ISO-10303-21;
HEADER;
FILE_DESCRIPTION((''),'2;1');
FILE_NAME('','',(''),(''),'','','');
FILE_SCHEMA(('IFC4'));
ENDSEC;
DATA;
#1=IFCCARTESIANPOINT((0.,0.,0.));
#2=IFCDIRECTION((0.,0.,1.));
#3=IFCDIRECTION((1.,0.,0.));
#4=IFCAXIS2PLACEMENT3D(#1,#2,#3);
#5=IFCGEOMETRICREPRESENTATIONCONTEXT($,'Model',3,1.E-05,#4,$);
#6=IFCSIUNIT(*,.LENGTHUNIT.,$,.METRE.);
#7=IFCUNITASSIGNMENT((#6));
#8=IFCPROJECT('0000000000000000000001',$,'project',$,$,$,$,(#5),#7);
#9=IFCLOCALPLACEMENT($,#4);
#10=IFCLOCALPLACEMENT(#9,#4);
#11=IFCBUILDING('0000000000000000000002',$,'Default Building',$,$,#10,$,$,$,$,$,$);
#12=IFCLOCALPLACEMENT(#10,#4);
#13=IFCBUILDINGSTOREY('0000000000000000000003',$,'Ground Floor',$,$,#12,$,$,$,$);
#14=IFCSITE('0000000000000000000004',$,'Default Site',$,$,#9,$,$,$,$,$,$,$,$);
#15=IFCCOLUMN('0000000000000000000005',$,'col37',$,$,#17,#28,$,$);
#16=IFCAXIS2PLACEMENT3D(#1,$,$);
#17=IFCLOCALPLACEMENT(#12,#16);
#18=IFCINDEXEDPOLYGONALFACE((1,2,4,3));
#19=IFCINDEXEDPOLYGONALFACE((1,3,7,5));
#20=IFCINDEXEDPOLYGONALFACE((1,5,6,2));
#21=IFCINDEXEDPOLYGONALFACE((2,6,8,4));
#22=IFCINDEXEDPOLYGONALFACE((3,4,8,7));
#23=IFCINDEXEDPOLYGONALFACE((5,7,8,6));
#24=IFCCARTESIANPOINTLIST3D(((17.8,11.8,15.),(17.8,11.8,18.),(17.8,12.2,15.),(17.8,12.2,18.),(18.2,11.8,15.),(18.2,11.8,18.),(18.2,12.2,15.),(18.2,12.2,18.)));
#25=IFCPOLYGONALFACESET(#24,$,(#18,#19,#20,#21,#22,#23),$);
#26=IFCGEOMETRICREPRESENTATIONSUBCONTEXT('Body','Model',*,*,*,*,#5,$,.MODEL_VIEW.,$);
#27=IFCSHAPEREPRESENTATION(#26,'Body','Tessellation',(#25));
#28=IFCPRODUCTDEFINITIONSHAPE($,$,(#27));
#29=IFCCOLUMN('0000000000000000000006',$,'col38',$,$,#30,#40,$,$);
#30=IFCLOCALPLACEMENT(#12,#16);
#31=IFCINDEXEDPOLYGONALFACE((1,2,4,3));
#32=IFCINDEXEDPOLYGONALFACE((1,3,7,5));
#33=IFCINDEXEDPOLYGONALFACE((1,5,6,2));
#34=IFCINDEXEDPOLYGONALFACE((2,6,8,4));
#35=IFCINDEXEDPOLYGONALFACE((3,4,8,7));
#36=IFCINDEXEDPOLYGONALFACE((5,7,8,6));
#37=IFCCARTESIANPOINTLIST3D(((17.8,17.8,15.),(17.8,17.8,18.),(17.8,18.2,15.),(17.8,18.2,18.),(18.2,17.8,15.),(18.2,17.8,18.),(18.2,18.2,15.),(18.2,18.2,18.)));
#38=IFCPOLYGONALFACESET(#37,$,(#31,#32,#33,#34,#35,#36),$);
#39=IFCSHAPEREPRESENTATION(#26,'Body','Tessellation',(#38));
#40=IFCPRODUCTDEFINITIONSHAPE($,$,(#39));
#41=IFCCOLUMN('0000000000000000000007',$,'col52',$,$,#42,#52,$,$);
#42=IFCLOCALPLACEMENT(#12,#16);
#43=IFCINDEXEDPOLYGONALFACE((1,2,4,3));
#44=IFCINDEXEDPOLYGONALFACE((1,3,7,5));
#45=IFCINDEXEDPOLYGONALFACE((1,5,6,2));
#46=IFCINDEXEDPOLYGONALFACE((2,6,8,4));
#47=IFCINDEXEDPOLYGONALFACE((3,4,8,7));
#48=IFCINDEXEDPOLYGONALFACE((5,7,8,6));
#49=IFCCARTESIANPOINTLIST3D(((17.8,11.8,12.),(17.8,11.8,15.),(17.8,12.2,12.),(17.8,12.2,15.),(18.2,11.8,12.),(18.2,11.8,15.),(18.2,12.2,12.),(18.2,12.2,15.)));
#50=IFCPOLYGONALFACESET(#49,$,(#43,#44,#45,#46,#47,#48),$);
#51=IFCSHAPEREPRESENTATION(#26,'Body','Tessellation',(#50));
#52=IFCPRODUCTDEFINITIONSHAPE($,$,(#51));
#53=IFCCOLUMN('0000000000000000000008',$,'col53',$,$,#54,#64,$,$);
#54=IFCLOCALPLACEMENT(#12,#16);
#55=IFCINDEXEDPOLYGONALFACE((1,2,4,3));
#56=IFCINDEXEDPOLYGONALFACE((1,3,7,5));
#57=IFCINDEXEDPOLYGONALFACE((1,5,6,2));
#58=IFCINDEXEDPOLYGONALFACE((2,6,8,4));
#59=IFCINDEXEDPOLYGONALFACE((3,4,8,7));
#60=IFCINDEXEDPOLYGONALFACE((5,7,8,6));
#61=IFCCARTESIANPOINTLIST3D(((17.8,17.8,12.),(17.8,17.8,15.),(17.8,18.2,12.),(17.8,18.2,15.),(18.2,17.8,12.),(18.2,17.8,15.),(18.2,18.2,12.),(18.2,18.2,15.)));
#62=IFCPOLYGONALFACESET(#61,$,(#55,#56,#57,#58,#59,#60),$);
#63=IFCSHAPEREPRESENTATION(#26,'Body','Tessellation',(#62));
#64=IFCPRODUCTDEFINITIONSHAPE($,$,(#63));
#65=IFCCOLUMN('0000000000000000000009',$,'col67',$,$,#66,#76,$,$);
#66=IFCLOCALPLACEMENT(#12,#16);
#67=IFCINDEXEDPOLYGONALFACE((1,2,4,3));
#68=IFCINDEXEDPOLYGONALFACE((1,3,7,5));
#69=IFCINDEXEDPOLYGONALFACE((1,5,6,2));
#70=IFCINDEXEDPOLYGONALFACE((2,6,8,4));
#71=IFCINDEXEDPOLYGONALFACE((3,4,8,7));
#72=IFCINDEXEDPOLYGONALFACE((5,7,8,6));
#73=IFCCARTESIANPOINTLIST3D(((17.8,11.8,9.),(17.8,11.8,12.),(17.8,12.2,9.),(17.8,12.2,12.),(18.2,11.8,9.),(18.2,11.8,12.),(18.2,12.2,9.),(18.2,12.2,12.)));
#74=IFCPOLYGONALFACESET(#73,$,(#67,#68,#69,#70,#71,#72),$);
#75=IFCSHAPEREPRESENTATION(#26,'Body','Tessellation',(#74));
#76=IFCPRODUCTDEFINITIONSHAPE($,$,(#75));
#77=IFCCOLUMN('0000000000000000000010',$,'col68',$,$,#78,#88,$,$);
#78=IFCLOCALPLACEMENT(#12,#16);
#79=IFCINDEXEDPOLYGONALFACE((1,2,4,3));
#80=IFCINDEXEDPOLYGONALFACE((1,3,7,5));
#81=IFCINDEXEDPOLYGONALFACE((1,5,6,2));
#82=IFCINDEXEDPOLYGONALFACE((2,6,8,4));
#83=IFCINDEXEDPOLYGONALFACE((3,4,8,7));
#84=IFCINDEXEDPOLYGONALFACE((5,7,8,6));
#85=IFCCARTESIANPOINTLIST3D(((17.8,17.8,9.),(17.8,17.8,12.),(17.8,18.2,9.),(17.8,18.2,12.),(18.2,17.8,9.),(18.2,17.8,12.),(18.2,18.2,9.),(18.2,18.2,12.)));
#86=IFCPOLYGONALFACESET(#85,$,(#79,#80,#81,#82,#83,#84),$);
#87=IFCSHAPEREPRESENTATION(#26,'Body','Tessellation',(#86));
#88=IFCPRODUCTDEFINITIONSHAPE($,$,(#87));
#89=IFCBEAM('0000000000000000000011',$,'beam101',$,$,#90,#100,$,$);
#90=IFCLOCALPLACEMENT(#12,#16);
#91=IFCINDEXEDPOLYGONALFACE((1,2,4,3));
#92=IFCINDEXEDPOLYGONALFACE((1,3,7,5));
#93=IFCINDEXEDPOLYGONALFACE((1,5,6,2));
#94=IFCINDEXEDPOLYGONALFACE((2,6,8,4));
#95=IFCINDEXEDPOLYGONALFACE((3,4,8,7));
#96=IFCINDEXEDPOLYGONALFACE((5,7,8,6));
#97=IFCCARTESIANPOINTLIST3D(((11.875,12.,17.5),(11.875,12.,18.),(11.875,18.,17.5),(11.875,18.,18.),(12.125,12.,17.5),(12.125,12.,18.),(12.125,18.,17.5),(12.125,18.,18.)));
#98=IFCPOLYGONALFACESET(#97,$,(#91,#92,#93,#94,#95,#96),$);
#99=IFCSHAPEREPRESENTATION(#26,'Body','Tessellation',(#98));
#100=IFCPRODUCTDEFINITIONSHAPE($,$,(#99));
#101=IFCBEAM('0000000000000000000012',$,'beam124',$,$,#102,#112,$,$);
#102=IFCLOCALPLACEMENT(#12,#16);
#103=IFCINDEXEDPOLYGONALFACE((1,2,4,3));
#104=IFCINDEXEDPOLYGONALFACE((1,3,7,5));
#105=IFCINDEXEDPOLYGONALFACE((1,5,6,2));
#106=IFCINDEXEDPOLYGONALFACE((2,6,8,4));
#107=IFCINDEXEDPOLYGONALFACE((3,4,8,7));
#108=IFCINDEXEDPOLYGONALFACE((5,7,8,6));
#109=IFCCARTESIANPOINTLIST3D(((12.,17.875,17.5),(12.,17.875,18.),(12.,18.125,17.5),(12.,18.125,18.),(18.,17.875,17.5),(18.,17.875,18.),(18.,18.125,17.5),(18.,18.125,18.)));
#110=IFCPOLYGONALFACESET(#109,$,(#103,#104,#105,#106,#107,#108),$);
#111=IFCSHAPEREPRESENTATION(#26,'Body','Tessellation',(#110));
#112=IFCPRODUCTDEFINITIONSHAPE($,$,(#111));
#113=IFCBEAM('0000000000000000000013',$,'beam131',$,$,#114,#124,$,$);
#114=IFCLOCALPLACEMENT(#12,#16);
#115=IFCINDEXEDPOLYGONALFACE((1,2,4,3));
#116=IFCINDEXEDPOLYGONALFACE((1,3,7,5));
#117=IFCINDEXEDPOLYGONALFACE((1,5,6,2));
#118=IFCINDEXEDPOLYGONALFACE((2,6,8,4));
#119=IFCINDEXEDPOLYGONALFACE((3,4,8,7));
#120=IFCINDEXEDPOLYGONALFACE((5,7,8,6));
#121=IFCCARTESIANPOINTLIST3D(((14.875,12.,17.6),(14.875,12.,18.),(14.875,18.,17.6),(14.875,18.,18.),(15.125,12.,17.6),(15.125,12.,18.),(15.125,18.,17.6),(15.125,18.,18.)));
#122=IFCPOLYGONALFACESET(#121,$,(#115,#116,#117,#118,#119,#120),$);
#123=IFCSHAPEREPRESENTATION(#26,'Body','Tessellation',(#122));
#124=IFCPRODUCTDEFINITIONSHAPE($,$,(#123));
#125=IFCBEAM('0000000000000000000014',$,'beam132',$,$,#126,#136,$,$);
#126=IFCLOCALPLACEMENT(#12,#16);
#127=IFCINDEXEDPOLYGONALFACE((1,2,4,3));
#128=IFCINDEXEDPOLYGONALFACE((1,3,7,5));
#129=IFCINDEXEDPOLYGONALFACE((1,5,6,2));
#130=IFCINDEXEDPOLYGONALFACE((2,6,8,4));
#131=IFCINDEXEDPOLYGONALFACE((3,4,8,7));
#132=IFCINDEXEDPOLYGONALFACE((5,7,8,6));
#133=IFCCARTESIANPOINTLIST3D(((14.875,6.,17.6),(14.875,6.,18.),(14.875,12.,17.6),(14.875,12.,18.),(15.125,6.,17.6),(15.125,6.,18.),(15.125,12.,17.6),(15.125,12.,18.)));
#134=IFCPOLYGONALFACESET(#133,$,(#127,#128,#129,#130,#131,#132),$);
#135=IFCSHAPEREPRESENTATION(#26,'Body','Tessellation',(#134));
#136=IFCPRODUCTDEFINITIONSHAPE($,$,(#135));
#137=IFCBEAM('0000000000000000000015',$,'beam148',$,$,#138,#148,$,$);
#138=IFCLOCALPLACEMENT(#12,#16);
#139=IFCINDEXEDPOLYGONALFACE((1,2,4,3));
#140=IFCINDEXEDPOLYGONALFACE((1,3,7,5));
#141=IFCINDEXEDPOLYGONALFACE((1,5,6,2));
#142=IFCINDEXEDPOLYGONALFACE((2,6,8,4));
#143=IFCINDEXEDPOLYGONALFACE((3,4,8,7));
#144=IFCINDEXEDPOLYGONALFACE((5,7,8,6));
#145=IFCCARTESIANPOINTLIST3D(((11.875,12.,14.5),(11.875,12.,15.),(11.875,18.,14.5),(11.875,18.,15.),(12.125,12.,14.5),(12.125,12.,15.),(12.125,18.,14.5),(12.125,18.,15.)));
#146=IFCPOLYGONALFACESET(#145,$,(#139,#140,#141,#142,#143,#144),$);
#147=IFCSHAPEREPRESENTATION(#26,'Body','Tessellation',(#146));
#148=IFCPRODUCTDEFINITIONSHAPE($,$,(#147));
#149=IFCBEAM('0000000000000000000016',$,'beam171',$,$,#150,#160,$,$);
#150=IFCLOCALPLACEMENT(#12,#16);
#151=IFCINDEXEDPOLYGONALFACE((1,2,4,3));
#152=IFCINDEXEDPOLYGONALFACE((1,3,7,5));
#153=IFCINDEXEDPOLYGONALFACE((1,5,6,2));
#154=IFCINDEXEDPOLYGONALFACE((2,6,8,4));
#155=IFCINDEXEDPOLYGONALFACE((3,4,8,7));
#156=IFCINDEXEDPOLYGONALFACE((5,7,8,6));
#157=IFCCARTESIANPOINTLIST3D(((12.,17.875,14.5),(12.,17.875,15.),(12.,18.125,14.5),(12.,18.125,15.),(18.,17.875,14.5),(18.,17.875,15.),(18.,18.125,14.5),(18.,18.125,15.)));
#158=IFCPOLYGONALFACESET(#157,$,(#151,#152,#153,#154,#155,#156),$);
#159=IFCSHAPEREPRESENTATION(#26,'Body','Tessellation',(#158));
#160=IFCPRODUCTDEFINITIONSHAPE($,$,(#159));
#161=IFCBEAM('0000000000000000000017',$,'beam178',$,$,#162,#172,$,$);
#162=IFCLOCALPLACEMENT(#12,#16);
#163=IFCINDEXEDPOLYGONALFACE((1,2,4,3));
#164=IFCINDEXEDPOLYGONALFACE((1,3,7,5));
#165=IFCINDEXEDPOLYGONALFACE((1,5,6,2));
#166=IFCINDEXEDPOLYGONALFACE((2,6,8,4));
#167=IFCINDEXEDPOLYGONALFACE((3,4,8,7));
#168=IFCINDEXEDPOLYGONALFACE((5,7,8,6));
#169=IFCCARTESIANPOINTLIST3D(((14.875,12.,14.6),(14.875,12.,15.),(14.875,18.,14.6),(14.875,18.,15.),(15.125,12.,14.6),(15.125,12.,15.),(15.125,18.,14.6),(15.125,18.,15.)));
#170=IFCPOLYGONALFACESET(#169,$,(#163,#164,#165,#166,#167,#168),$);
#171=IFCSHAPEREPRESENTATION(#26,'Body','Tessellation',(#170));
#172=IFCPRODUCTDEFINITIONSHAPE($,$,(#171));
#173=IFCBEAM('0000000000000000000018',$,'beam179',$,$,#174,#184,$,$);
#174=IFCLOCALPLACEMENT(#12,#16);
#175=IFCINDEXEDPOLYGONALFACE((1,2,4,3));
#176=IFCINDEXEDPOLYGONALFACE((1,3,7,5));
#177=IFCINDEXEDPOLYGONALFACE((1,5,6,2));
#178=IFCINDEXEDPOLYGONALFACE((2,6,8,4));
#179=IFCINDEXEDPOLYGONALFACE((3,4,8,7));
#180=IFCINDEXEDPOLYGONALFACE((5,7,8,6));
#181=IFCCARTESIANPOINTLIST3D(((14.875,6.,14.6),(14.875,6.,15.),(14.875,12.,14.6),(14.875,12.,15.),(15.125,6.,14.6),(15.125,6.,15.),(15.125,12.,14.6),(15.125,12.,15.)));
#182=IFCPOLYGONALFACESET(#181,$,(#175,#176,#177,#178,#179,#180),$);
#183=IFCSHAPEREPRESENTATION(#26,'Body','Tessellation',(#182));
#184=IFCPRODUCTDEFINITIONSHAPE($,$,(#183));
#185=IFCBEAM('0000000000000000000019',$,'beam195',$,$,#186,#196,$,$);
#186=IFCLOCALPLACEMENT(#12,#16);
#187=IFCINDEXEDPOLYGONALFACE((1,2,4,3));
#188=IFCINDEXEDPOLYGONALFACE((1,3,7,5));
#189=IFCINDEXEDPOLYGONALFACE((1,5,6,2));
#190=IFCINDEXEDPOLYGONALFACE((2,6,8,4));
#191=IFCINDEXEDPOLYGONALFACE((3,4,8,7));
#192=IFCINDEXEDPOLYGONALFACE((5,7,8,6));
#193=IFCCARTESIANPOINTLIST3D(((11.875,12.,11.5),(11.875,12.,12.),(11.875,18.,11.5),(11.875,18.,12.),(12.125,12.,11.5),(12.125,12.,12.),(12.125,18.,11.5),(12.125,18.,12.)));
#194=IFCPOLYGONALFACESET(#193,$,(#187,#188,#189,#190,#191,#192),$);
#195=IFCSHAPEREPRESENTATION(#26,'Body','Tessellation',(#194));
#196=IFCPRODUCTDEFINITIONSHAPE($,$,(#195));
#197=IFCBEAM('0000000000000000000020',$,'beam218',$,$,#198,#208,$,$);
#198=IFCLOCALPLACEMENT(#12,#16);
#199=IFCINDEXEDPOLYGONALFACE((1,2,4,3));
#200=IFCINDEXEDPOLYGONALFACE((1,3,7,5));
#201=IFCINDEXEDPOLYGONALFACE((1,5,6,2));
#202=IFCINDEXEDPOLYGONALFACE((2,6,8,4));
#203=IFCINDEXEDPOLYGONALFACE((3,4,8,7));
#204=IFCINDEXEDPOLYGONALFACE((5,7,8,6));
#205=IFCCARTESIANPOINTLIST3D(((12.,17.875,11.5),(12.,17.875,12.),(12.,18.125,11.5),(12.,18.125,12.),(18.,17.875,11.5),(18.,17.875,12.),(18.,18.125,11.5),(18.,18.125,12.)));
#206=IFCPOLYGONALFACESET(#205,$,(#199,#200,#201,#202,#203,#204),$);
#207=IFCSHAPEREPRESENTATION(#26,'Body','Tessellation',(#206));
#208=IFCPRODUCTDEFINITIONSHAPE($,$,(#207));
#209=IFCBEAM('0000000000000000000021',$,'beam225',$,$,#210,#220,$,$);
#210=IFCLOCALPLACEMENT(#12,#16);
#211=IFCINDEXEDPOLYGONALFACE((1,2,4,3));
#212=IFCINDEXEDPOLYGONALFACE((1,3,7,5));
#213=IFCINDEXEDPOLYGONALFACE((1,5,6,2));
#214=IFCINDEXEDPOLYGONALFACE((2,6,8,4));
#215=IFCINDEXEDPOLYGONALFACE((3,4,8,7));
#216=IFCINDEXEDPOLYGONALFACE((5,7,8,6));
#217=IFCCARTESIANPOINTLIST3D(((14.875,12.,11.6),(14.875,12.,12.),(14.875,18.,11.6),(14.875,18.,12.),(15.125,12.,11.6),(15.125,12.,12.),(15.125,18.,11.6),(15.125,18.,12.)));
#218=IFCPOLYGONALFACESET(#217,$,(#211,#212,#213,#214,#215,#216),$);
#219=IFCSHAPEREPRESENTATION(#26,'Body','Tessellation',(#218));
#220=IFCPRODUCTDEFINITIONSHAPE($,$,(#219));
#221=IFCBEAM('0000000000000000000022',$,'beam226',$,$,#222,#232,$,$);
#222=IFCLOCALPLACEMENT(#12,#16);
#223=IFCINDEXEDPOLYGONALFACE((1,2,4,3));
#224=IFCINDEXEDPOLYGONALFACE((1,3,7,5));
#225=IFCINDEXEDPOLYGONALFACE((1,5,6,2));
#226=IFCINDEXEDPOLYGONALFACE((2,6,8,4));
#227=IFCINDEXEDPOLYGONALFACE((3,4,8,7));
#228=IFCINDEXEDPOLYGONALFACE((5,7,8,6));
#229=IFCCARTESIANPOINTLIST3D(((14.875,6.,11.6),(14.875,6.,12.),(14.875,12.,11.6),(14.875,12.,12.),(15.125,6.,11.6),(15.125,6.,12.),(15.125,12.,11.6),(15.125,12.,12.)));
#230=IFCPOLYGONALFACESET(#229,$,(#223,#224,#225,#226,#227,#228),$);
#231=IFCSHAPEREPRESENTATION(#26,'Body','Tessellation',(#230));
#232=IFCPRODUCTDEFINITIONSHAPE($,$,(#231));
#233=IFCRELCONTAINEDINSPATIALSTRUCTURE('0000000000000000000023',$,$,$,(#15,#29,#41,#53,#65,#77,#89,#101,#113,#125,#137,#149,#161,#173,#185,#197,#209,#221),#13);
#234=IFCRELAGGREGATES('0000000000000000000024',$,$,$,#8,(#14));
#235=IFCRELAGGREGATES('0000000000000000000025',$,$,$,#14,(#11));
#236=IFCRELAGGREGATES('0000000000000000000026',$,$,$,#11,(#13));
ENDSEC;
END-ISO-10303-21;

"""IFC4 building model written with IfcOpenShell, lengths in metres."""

from ifc_helpers import new_model, si_unit, frame, origin_with_axes, place, context, subcontext, project, spatial, indexed_curve, outline, extrude, element, save


model = new_model("IFC4")

# Units and contexts
model_context = context("Model", 3, precision=1e-05, world=origin_with_axes())
body_context = subcontext(model_context, "Body", "Model", "MODEL_VIEW")
ifc_project = project(units=[si_unit("LENGTHUNIT", "METRE")], contexts=[model_context])

# Site, building, storey
site_placement = place(None, origin_with_axes())
site = spatial("IfcSite", under=ifc_project, at=site_placement, Name="Default Site")
building_placement = place(site_placement, origin_with_axes())
building = spatial("IfcBuilding", under=site, at=building_placement, Name="Default Building")
storey_placement = place(building_placement, origin_with_axes())
storey = spatial("IfcBuildingStorey", under=building, at=storey_placement, Name="Ground Floor")

# Columns
for number, where, z_axis, x_axis, name in (
    (1, (17.8, 11.8, 15.0), (0.0, 0.0, 1.0), (1.0, 0.0, 0.0), "col37"),
    (2, (17.8, 17.8, 15.0), (0.0, 0.0, 1.0), (1.0, 0.0, 0.0), "col38"),
    (3, (17.8, 11.8, 12.0), (0.0, 0.0, 1.0), (1.0, 0.0, 0.0), "col52"),
    (4, (17.8, 17.8, 12.0), (0.0, 0.0, 1.0), (1.0, 0.0, 0.0), "col53"),
    (5, (17.8, 11.8, 9.0), (0.0, 0.0, 1.0), (1.0, 0.0, 0.0), "col67"),
    (6, (17.8, 17.8, 9.0), (0.0, 0.0, 1.0), (1.0, 0.0, 0.0), "col68"),
):
    element("IfcColumn", number, at=place(storey_placement, frame(where, z_axis=z_axis, x_axis=x_axis)), inside=storey, Name=name, context=body_context, shape_type="SweptSolid", body=[
        extrude(outline(indexed_curve([(0.0, 0.0), (0.0, 0.4), (0.4, 0.4), (0.4, 0.0), (0.0, 0.0)], self_intersect=False)), origin_with_axes(), (0.0, 0.0, 1.0), 3.0),
    ])

# Beams
for number, where, z_axis, x_axis, name in (
    (7, (12.125, 12.0, 17.5), (0.0, 0.0, 1.0), (0.0, 1.0, 0.0), "beam101"),
    (8, (12.0, 17.875, 17.5), (0.0, 0.0, 1.0), (1.0, 0.0, 0.0), "beam124"),
):
    element("IfcBeam", number, at=place(storey_placement, frame(where, z_axis=z_axis, x_axis=x_axis)), inside=storey, Name=name, context=body_context, shape_type="SweptSolid", body=[
        extrude(outline(indexed_curve([(0.0, 0.0), (0.0, 0.25), (6.0, 0.25), (6.0, 0.0), (0.0, 0.0)], self_intersect=False)), origin_with_axes(), (0.0, 0.0, 1.0), 0.5),
    ])
for number, where, z_axis, x_axis, name in (
    (9, (14.875, 18.0, 17.6), (0.0, 0.0, 1.0), (0.0, -1.0, 0.0), "beam131"),
    (10, (14.875, 12.0, 17.6), (0.0, 0.0, 1.0), (0.0, -1.0, 0.0), "beam132"),
):
    element("IfcBeam", number, at=place(storey_placement, frame(where, z_axis=z_axis, x_axis=x_axis)), inside=storey, Name=name, context=body_context, shape_type="SweptSolid", body=[
        extrude(outline(indexed_curve([(0.0, 0.0), (0.0, 0.25), (6.0, 0.25), (6.0, 0.0), (0.0, 0.0)], self_intersect=False)), origin_with_axes(), (0.0, 0.0, 1.0), 0.4),
    ])
for number, where, z_axis, x_axis, name in (
    (11, (12.125, 12.0, 14.5), (0.0, 0.0, 1.0), (0.0, 1.0, 0.0), "beam148"),
    (12, (12.0, 17.875, 14.5), (0.0, 0.0, 1.0), (1.0, 0.0, 0.0), "beam171"),
):
    element("IfcBeam", number, at=place(storey_placement, frame(where, z_axis=z_axis, x_axis=x_axis)), inside=storey, Name=name, context=body_context, shape_type="SweptSolid", body=[
        extrude(outline(indexed_curve([(0.0, 0.0), (0.0, 0.25), (6.0, 0.25), (6.0, 0.0), (0.0, 0.0)], self_intersect=False)), origin_with_axes(), (0.0, 0.0, 1.0), 0.5),
    ])
for number, where, z_axis, x_axis, name in (
    (13, (14.875, 18.0, 14.6), (0.0, 0.0, 1.0), (0.0, -1.0, 0.0), "beam178"),
    (14, (14.875, 12.0, 14.6), (0.0, 0.0, 1.0), (0.0, -1.0, 0.0), "beam179"),
):
    element("IfcBeam", number, at=place(storey_placement, frame(where, z_axis=z_axis, x_axis=x_axis)), inside=storey, Name=name, context=body_context, shape_type="SweptSolid", body=[
        extrude(outline(indexed_curve([(0.0, 0.0), (0.0, 0.25), (6.0, 0.25), (6.0, 0.0), (0.0, 0.0)], self_intersect=False)), origin_with_axes(), (0.0, 0.0, 1.0), 0.4),
    ])
for number, where, z_axis, x_axis, name in (
    (15, (12.125, 12.0, 11.5), (0.0, 0.0, 1.0), (0.0, 1.0, 0.0), "beam195"),
    (16, (12.0, 17.875, 11.5), (0.0, 0.0, 1.0), (1.0, 0.0, 0.0), "beam218"),
):
    element("IfcBeam", number, at=place(storey_placement, frame(where, z_axis=z_axis, x_axis=x_axis)), inside=storey, Name=name, context=body_context, shape_type="SweptSolid", body=[
        extrude(outline(indexed_curve([(0.0, 0.0), (0.0, 0.25), (6.0, 0.25), (6.0, 0.0), (0.0, 0.0)], self_intersect=False)), origin_with_axes(), (0.0, 0.0, 1.0), 0.5),
    ])
for number, where, z_axis, x_axis, name in (
    (17, (14.875, 18.0, 11.6), (0.0, 0.0, 1.0), (0.0, -1.0, 0.0), "beam225"),
    (18, (14.875, 12.0, 11.6), (0.0, 0.0, 1.0), (0.0, -1.0, 0.0), "beam226"),
):
    element("IfcBeam", number, at=place(storey_placement, frame(where, z_axis=z_axis, x_axis=x_axis)), inside=storey, Name=name, context=body_context, shape_type="SweptSolid", body=[
        extrude(outline(indexed_curve([(0.0, 0.0), (0.0, 0.25), (6.0, 0.25), (6.0, 0.0), (0.0, 0.0)], self_intersect=False)), origin_with_axes(), (0.0, 0.0, 1.0), 0.4),
    ])

save(model, "model.ifc")
